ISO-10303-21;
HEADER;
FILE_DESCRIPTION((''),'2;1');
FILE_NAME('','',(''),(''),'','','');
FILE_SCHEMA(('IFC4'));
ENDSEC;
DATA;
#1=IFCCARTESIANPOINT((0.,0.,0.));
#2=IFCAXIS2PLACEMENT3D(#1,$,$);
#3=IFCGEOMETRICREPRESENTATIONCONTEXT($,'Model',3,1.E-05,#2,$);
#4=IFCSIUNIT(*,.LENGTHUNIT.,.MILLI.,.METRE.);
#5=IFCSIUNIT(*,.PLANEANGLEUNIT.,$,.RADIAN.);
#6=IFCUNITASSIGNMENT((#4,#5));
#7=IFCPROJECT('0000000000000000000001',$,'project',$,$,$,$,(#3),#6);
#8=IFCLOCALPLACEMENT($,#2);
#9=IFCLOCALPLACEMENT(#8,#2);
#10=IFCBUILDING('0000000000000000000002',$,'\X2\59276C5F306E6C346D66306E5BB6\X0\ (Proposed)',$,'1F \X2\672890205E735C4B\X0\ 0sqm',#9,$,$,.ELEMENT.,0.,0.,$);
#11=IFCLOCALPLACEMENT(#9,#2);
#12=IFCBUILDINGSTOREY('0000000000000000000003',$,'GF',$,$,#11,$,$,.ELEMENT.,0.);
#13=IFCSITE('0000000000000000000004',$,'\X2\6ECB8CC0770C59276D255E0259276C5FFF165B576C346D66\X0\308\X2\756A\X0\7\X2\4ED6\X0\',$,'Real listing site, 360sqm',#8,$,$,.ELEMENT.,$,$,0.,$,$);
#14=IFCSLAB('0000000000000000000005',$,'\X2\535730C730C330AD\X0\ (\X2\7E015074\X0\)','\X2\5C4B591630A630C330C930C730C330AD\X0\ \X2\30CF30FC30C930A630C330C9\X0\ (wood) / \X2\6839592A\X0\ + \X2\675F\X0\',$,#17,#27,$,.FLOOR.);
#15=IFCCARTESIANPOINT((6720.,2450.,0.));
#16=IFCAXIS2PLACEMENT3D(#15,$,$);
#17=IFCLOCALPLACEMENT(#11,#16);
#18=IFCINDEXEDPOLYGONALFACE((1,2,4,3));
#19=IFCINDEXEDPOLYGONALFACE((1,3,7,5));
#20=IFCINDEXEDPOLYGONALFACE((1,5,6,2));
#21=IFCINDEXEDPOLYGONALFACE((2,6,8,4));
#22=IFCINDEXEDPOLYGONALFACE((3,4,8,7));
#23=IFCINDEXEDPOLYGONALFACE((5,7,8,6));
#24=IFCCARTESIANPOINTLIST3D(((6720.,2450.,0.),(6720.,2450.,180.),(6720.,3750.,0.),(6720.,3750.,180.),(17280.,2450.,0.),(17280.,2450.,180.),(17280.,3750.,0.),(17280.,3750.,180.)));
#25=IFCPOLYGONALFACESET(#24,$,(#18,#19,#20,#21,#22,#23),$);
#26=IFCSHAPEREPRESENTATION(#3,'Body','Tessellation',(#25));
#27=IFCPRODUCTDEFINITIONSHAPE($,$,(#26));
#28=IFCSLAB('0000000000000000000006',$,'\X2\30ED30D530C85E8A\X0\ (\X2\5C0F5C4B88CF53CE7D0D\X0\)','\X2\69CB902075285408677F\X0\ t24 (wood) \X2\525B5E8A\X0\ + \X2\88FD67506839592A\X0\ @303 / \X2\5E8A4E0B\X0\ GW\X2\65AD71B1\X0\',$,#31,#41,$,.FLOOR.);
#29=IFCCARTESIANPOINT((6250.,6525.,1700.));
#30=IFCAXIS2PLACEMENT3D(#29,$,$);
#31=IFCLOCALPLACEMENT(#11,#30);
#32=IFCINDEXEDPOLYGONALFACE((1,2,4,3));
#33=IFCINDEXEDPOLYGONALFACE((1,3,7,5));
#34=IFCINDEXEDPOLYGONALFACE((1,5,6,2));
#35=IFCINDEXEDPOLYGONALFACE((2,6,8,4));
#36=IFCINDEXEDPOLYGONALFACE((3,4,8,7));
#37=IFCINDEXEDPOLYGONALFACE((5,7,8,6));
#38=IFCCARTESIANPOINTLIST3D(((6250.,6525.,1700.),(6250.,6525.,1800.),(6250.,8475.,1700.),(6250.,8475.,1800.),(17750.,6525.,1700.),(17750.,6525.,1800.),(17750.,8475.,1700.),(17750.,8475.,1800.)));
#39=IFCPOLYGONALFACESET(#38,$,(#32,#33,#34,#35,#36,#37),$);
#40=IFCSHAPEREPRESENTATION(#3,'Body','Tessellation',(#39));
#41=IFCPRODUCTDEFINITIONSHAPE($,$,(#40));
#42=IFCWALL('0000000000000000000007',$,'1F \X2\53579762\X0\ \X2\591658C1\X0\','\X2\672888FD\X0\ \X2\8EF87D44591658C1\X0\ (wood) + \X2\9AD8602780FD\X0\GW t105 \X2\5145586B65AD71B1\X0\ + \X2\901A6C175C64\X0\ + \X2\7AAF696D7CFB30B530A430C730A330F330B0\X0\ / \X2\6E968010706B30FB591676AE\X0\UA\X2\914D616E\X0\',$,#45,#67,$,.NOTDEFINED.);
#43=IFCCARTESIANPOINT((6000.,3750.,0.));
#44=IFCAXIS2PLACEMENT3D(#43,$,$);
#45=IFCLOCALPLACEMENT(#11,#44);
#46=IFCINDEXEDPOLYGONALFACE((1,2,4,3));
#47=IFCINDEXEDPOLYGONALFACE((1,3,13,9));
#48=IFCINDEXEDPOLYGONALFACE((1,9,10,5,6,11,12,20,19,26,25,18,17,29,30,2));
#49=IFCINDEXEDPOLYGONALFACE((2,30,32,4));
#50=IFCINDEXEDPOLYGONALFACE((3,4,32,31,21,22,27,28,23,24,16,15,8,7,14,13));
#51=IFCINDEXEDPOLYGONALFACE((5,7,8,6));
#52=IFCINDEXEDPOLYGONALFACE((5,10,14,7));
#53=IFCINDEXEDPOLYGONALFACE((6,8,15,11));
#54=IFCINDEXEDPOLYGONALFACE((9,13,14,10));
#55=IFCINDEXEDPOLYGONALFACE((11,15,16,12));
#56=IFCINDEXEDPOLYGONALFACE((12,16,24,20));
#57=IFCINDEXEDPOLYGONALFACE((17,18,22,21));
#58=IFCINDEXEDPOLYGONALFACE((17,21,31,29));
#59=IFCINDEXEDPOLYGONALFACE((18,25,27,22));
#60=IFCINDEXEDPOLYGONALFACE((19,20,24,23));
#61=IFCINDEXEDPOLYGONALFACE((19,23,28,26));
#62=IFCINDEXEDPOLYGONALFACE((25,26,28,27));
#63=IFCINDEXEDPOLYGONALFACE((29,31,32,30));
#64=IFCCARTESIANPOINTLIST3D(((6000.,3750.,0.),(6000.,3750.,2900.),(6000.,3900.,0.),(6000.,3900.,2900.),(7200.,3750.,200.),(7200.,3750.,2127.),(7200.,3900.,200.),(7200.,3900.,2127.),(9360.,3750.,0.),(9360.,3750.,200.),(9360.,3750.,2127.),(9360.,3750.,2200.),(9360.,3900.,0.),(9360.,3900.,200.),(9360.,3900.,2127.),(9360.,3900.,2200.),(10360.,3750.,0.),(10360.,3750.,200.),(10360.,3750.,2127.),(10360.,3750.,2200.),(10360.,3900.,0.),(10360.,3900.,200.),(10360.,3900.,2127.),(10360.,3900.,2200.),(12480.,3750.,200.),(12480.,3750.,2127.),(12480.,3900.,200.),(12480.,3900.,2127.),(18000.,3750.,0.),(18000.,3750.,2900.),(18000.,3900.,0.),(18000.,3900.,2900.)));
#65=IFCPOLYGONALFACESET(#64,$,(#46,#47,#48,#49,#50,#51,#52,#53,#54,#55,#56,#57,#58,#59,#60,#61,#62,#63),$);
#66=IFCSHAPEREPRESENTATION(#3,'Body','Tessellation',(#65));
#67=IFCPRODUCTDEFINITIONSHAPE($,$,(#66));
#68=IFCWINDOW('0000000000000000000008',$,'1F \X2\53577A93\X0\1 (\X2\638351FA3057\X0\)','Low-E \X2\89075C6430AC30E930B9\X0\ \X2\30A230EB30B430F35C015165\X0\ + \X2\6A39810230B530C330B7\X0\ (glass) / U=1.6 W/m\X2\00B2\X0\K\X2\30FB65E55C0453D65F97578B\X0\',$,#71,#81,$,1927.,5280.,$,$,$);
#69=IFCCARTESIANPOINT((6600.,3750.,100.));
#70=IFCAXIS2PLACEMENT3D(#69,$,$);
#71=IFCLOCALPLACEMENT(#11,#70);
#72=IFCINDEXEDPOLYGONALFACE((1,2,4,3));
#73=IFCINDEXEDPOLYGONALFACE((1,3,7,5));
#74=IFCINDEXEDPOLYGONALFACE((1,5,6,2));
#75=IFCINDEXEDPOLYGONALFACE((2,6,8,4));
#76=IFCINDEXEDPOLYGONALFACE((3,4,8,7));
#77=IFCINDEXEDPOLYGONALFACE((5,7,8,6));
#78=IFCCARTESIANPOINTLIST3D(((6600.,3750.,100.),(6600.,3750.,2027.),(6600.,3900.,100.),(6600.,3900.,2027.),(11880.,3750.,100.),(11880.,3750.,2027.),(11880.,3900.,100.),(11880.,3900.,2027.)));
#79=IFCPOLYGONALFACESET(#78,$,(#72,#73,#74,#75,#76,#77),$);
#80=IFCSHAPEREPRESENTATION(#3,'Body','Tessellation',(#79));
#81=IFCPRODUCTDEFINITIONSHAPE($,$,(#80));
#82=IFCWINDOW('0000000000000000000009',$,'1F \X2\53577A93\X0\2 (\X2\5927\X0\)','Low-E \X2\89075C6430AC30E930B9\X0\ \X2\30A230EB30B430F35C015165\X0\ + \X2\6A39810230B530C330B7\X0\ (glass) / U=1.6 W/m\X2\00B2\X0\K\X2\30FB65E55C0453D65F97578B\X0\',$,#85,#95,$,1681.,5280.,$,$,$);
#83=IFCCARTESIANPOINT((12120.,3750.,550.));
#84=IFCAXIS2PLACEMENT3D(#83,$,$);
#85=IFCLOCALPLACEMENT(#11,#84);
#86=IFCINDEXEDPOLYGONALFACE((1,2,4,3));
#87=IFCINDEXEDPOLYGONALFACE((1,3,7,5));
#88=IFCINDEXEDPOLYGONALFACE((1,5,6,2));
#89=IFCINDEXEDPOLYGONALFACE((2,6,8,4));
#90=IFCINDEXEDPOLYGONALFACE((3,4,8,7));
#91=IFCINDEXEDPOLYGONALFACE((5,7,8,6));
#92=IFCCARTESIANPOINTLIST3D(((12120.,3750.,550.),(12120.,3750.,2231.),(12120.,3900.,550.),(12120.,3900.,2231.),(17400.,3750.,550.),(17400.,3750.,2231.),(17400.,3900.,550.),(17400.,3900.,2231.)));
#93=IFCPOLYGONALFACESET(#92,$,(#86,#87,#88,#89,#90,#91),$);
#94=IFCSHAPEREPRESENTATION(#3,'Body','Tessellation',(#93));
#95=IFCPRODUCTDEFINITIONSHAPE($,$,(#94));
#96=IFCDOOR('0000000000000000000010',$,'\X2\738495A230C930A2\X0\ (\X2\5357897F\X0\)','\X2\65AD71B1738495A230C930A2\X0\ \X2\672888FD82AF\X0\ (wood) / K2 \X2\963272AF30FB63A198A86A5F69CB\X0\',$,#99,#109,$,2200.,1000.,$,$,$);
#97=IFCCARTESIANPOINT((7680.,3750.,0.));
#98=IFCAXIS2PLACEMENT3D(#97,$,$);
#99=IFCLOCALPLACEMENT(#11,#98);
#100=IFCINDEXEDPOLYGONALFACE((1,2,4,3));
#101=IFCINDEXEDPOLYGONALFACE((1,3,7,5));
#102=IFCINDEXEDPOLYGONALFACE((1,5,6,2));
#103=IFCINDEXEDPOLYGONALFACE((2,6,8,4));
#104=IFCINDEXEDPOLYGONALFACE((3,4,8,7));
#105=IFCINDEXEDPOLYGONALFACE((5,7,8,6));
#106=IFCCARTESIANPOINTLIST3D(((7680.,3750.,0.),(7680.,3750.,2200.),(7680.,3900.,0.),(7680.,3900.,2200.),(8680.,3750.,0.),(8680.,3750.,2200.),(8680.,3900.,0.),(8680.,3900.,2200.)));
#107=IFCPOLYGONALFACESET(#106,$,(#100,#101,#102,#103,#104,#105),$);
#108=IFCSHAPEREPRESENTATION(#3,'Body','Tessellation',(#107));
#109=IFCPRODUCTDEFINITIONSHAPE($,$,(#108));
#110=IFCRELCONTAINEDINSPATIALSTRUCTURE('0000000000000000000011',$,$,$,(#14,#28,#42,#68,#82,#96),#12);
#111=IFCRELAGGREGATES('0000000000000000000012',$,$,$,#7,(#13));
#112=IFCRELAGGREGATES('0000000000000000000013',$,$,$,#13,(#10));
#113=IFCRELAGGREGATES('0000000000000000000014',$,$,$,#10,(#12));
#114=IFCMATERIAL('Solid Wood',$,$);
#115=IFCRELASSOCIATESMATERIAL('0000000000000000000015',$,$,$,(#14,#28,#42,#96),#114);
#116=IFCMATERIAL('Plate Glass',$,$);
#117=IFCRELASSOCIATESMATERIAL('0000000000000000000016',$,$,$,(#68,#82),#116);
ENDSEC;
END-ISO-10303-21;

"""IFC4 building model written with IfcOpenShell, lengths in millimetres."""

from ifc_helpers import new_model, si_unit, frame, frame_2d, origin, place, context, project, spatial, rectangle, extrude, material, element, fill, save


model = new_model("IFC4")

# Units and contexts
model_context = context("Model", 3, precision=1e-05, world=origin())
ifc_project = project(units=[si_unit("LENGTHUNIT", "METRE", prefix="MILLI"), si_unit("PLANEANGLEUNIT", "RADIAN")], contexts=[model_context])

# Site, building, storey
site_placement = place(None, origin())
site = spatial("IfcSite", under=ifc_project, at=site_placement, Name="滋賀県大津市大江６字水浦308番7他", ObjectType="Real listing site, 360sqm", CompositionType="ELEMENT", RefElevation=0.0)
building_placement = place(site_placement, origin())
building = spatial("IfcBuilding", under=site, at=building_placement, Name="大江の水浦の家 (Proposed)", ObjectType="1F 木造平屋 0sqm", CompositionType="ELEMENT", ElevationOfRefHeight=0.0, ElevationOfTerrain=0.0)
storey_placement = place(building_placement, origin())
storey = spatial("IfcBuildingStorey", under=building, at=storey_placement, Name="GF", CompositionType="ELEMENT", Elevation=0.0)

# Slabs
ifc_material_1 = material(Name="Solid Wood")
slab_1_placement = place(storey_placement, frame((6720.0, 2450.0, 0.0)))
element("IfcSlab", 1, at=slab_1_placement, inside=storey, material=ifc_material_1, Name="南デッキ (縁側)", Description="屋外ウッドデッキ ハードウッド (wood) / 根太 + 束", PredefinedType="FLOOR", context=model_context, shape_type="SweptSolid", body=[
    extrude(rectangle(XDim=10560.0, YDim=1300.0, at=frame_2d((5280.0, 650.0))), frame((6720.0, 2450.0, 0.0)), (0.0, 0.0, 1.0), 180.0),
])
slab_2_placement = place(storey_placement, frame((6250.0, 6525.0, 1700.0)))
element("IfcSlab", 2, at=slab_2_placement, inside=storey, material=ifc_material_1, Name="ロフト床 (小屋裏収納)", Description="構造用合板 t24 (wood) 剛床 + 製材根太 @303 / 床下 GW断熱", PredefinedType="FLOOR", context=model_context, shape_type="SweptSolid", body=[
    extrude(rectangle(XDim=11500.0, YDim=1950.0, at=frame_2d((5750.0, 975.0))), frame((6250.0, 6525.0, 1700.0)), (0.0, 0.0, 1.0), 100.0),
])

# Wall, openings, windows, door
wall_1_placement = place(storey_placement, frame((6000.0, 3750.0, 0.0)))
wall_1 = element("IfcWall", 3, at=wall_1_placement, inside=storey, material=ifc_material_1, Name="1F 南面 外壁", Description="木製 軸組外壁 (wood) + 高性能GW t105 充填断熱 + 通気層 + 窯業系サイディング / 準耐火・外皮UA配慮", PredefinedType="NOTDEFINED", context=model_context, shape_type="SweptSolid", body=[
    extrude(rectangle(XDim=12000.0, YDim=150.0, at=frame_2d((6000.0, 75.0))), frame((6000.0, 3750.0, 0.0)), (0.0, 0.0, 1.0), 2900.0),
])
opening_1_placement = place(storey_placement, frame((6600.0, 3750.0, 100.0)))
opening_1 = element("IfcOpeningElement", 4, at=opening_1_placement, cuts=wall_1, PredefinedType="NOTDEFINED", context=model_context, shape_type="SweptSolid", body=[
    extrude(rectangle(XDim=5280.0, YDim=150.0, at=frame_2d((2640.0, 75.0))), frame((6600.0, 3750.0, 100.0)), (0.0, 0.0, 1.0), 1927.0),
])
opening_2_placement = place(storey_placement, frame((12120.0, 3750.0, 550.0)))
opening_2 = element("IfcOpeningElement", 5, at=opening_2_placement, cuts=wall_1, PredefinedType="NOTDEFINED", context=model_context, shape_type="SweptSolid", body=[
    extrude(rectangle(XDim=5280.0, YDim=150.0, at=frame_2d((2640.0, 75.0))), frame((12120.0, 3750.0, 550.0)), (0.0, 0.0, 1.0), 1681.0),
])
opening_3_placement = place(storey_placement, frame((7680.0, 3750.0, 0.0)))
opening_3 = element("IfcOpeningElement", 6, at=opening_3_placement, cuts=wall_1, PredefinedType="NOTDEFINED", context=model_context, shape_type="SweptSolid", body=[
    extrude(rectangle(XDim=1000.0, YDim=150.0, at=frame_2d((500.0, 75.0))), frame((7680.0, 3750.0, 0.0)), (0.0, 0.0, 1.0), 2200.0),
])
ifc_material_2 = material(Name="Plate Glass")
window_1_placement = place(storey_placement, frame((6600.0, 3750.0, 100.0)))
window_1 = element("IfcWindow", 7, at=window_1_placement, inside=storey, material=ifc_material_2, Name="1F 南窓1 (掃出し)", Description="Low-E 複層ガラス アルゴン封入 + 樹脂サッシ (glass) / U=1.6 W/m²K・日射取得型", OverallHeight=1927.0, OverallWidth=5280.0, context=model_context, shape_type="SweptSolid", body=[
    extrude(rectangle(XDim=5280.0, YDim=150.0, at=frame_2d((2640.0, 75.0))), frame((6600.0, 3750.0, 100.0)), (0.0, 0.0, 1.0), 1927.0),
])
fill(opening_1, window_1)
window_2_placement = place(storey_placement, frame((12120.0, 3750.0, 550.0)))
window_2 = element("IfcWindow", 8, at=window_2_placement, inside=storey, material=ifc_material_2, Name="1F 南窓2 (大)", Description="Low-E 複層ガラス アルゴン封入 + 樹脂サッシ (glass) / U=1.6 W/m²K・日射取得型", OverallHeight=1681.0, OverallWidth=5280.0, context=model_context, shape_type="SweptSolid", body=[
    extrude(rectangle(XDim=5280.0, YDim=150.0, at=frame_2d((2640.0, 75.0))), frame((12120.0, 3750.0, 550.0)), (0.0, 0.0, 1.0), 1681.0),
])
fill(opening_2, window_2)
door_1_placement = place(storey_placement, frame((7680.0, 3750.0, 0.0)))
door_1 = element("IfcDoor", 9, at=door_1_placement, inside=storey, material=ifc_material_1, Name="玄関ドア (南西)", Description="断熱玄関ドア 木製芯 (wood) / K2 防犯・採風機構", OverallHeight=2200.0, OverallWidth=1000.0, context=model_context, shape_type="SweptSolid", body=[
    extrude(rectangle(XDim=1000.0, YDim=150.0, at=frame_2d((500.0, 75.0))), frame((7680.0, 3750.0, 0.0)), (0.0, 0.0, 1.0), 2200.0),
])
fill(opening_3, door_1)

save(model, "model.ifc")
